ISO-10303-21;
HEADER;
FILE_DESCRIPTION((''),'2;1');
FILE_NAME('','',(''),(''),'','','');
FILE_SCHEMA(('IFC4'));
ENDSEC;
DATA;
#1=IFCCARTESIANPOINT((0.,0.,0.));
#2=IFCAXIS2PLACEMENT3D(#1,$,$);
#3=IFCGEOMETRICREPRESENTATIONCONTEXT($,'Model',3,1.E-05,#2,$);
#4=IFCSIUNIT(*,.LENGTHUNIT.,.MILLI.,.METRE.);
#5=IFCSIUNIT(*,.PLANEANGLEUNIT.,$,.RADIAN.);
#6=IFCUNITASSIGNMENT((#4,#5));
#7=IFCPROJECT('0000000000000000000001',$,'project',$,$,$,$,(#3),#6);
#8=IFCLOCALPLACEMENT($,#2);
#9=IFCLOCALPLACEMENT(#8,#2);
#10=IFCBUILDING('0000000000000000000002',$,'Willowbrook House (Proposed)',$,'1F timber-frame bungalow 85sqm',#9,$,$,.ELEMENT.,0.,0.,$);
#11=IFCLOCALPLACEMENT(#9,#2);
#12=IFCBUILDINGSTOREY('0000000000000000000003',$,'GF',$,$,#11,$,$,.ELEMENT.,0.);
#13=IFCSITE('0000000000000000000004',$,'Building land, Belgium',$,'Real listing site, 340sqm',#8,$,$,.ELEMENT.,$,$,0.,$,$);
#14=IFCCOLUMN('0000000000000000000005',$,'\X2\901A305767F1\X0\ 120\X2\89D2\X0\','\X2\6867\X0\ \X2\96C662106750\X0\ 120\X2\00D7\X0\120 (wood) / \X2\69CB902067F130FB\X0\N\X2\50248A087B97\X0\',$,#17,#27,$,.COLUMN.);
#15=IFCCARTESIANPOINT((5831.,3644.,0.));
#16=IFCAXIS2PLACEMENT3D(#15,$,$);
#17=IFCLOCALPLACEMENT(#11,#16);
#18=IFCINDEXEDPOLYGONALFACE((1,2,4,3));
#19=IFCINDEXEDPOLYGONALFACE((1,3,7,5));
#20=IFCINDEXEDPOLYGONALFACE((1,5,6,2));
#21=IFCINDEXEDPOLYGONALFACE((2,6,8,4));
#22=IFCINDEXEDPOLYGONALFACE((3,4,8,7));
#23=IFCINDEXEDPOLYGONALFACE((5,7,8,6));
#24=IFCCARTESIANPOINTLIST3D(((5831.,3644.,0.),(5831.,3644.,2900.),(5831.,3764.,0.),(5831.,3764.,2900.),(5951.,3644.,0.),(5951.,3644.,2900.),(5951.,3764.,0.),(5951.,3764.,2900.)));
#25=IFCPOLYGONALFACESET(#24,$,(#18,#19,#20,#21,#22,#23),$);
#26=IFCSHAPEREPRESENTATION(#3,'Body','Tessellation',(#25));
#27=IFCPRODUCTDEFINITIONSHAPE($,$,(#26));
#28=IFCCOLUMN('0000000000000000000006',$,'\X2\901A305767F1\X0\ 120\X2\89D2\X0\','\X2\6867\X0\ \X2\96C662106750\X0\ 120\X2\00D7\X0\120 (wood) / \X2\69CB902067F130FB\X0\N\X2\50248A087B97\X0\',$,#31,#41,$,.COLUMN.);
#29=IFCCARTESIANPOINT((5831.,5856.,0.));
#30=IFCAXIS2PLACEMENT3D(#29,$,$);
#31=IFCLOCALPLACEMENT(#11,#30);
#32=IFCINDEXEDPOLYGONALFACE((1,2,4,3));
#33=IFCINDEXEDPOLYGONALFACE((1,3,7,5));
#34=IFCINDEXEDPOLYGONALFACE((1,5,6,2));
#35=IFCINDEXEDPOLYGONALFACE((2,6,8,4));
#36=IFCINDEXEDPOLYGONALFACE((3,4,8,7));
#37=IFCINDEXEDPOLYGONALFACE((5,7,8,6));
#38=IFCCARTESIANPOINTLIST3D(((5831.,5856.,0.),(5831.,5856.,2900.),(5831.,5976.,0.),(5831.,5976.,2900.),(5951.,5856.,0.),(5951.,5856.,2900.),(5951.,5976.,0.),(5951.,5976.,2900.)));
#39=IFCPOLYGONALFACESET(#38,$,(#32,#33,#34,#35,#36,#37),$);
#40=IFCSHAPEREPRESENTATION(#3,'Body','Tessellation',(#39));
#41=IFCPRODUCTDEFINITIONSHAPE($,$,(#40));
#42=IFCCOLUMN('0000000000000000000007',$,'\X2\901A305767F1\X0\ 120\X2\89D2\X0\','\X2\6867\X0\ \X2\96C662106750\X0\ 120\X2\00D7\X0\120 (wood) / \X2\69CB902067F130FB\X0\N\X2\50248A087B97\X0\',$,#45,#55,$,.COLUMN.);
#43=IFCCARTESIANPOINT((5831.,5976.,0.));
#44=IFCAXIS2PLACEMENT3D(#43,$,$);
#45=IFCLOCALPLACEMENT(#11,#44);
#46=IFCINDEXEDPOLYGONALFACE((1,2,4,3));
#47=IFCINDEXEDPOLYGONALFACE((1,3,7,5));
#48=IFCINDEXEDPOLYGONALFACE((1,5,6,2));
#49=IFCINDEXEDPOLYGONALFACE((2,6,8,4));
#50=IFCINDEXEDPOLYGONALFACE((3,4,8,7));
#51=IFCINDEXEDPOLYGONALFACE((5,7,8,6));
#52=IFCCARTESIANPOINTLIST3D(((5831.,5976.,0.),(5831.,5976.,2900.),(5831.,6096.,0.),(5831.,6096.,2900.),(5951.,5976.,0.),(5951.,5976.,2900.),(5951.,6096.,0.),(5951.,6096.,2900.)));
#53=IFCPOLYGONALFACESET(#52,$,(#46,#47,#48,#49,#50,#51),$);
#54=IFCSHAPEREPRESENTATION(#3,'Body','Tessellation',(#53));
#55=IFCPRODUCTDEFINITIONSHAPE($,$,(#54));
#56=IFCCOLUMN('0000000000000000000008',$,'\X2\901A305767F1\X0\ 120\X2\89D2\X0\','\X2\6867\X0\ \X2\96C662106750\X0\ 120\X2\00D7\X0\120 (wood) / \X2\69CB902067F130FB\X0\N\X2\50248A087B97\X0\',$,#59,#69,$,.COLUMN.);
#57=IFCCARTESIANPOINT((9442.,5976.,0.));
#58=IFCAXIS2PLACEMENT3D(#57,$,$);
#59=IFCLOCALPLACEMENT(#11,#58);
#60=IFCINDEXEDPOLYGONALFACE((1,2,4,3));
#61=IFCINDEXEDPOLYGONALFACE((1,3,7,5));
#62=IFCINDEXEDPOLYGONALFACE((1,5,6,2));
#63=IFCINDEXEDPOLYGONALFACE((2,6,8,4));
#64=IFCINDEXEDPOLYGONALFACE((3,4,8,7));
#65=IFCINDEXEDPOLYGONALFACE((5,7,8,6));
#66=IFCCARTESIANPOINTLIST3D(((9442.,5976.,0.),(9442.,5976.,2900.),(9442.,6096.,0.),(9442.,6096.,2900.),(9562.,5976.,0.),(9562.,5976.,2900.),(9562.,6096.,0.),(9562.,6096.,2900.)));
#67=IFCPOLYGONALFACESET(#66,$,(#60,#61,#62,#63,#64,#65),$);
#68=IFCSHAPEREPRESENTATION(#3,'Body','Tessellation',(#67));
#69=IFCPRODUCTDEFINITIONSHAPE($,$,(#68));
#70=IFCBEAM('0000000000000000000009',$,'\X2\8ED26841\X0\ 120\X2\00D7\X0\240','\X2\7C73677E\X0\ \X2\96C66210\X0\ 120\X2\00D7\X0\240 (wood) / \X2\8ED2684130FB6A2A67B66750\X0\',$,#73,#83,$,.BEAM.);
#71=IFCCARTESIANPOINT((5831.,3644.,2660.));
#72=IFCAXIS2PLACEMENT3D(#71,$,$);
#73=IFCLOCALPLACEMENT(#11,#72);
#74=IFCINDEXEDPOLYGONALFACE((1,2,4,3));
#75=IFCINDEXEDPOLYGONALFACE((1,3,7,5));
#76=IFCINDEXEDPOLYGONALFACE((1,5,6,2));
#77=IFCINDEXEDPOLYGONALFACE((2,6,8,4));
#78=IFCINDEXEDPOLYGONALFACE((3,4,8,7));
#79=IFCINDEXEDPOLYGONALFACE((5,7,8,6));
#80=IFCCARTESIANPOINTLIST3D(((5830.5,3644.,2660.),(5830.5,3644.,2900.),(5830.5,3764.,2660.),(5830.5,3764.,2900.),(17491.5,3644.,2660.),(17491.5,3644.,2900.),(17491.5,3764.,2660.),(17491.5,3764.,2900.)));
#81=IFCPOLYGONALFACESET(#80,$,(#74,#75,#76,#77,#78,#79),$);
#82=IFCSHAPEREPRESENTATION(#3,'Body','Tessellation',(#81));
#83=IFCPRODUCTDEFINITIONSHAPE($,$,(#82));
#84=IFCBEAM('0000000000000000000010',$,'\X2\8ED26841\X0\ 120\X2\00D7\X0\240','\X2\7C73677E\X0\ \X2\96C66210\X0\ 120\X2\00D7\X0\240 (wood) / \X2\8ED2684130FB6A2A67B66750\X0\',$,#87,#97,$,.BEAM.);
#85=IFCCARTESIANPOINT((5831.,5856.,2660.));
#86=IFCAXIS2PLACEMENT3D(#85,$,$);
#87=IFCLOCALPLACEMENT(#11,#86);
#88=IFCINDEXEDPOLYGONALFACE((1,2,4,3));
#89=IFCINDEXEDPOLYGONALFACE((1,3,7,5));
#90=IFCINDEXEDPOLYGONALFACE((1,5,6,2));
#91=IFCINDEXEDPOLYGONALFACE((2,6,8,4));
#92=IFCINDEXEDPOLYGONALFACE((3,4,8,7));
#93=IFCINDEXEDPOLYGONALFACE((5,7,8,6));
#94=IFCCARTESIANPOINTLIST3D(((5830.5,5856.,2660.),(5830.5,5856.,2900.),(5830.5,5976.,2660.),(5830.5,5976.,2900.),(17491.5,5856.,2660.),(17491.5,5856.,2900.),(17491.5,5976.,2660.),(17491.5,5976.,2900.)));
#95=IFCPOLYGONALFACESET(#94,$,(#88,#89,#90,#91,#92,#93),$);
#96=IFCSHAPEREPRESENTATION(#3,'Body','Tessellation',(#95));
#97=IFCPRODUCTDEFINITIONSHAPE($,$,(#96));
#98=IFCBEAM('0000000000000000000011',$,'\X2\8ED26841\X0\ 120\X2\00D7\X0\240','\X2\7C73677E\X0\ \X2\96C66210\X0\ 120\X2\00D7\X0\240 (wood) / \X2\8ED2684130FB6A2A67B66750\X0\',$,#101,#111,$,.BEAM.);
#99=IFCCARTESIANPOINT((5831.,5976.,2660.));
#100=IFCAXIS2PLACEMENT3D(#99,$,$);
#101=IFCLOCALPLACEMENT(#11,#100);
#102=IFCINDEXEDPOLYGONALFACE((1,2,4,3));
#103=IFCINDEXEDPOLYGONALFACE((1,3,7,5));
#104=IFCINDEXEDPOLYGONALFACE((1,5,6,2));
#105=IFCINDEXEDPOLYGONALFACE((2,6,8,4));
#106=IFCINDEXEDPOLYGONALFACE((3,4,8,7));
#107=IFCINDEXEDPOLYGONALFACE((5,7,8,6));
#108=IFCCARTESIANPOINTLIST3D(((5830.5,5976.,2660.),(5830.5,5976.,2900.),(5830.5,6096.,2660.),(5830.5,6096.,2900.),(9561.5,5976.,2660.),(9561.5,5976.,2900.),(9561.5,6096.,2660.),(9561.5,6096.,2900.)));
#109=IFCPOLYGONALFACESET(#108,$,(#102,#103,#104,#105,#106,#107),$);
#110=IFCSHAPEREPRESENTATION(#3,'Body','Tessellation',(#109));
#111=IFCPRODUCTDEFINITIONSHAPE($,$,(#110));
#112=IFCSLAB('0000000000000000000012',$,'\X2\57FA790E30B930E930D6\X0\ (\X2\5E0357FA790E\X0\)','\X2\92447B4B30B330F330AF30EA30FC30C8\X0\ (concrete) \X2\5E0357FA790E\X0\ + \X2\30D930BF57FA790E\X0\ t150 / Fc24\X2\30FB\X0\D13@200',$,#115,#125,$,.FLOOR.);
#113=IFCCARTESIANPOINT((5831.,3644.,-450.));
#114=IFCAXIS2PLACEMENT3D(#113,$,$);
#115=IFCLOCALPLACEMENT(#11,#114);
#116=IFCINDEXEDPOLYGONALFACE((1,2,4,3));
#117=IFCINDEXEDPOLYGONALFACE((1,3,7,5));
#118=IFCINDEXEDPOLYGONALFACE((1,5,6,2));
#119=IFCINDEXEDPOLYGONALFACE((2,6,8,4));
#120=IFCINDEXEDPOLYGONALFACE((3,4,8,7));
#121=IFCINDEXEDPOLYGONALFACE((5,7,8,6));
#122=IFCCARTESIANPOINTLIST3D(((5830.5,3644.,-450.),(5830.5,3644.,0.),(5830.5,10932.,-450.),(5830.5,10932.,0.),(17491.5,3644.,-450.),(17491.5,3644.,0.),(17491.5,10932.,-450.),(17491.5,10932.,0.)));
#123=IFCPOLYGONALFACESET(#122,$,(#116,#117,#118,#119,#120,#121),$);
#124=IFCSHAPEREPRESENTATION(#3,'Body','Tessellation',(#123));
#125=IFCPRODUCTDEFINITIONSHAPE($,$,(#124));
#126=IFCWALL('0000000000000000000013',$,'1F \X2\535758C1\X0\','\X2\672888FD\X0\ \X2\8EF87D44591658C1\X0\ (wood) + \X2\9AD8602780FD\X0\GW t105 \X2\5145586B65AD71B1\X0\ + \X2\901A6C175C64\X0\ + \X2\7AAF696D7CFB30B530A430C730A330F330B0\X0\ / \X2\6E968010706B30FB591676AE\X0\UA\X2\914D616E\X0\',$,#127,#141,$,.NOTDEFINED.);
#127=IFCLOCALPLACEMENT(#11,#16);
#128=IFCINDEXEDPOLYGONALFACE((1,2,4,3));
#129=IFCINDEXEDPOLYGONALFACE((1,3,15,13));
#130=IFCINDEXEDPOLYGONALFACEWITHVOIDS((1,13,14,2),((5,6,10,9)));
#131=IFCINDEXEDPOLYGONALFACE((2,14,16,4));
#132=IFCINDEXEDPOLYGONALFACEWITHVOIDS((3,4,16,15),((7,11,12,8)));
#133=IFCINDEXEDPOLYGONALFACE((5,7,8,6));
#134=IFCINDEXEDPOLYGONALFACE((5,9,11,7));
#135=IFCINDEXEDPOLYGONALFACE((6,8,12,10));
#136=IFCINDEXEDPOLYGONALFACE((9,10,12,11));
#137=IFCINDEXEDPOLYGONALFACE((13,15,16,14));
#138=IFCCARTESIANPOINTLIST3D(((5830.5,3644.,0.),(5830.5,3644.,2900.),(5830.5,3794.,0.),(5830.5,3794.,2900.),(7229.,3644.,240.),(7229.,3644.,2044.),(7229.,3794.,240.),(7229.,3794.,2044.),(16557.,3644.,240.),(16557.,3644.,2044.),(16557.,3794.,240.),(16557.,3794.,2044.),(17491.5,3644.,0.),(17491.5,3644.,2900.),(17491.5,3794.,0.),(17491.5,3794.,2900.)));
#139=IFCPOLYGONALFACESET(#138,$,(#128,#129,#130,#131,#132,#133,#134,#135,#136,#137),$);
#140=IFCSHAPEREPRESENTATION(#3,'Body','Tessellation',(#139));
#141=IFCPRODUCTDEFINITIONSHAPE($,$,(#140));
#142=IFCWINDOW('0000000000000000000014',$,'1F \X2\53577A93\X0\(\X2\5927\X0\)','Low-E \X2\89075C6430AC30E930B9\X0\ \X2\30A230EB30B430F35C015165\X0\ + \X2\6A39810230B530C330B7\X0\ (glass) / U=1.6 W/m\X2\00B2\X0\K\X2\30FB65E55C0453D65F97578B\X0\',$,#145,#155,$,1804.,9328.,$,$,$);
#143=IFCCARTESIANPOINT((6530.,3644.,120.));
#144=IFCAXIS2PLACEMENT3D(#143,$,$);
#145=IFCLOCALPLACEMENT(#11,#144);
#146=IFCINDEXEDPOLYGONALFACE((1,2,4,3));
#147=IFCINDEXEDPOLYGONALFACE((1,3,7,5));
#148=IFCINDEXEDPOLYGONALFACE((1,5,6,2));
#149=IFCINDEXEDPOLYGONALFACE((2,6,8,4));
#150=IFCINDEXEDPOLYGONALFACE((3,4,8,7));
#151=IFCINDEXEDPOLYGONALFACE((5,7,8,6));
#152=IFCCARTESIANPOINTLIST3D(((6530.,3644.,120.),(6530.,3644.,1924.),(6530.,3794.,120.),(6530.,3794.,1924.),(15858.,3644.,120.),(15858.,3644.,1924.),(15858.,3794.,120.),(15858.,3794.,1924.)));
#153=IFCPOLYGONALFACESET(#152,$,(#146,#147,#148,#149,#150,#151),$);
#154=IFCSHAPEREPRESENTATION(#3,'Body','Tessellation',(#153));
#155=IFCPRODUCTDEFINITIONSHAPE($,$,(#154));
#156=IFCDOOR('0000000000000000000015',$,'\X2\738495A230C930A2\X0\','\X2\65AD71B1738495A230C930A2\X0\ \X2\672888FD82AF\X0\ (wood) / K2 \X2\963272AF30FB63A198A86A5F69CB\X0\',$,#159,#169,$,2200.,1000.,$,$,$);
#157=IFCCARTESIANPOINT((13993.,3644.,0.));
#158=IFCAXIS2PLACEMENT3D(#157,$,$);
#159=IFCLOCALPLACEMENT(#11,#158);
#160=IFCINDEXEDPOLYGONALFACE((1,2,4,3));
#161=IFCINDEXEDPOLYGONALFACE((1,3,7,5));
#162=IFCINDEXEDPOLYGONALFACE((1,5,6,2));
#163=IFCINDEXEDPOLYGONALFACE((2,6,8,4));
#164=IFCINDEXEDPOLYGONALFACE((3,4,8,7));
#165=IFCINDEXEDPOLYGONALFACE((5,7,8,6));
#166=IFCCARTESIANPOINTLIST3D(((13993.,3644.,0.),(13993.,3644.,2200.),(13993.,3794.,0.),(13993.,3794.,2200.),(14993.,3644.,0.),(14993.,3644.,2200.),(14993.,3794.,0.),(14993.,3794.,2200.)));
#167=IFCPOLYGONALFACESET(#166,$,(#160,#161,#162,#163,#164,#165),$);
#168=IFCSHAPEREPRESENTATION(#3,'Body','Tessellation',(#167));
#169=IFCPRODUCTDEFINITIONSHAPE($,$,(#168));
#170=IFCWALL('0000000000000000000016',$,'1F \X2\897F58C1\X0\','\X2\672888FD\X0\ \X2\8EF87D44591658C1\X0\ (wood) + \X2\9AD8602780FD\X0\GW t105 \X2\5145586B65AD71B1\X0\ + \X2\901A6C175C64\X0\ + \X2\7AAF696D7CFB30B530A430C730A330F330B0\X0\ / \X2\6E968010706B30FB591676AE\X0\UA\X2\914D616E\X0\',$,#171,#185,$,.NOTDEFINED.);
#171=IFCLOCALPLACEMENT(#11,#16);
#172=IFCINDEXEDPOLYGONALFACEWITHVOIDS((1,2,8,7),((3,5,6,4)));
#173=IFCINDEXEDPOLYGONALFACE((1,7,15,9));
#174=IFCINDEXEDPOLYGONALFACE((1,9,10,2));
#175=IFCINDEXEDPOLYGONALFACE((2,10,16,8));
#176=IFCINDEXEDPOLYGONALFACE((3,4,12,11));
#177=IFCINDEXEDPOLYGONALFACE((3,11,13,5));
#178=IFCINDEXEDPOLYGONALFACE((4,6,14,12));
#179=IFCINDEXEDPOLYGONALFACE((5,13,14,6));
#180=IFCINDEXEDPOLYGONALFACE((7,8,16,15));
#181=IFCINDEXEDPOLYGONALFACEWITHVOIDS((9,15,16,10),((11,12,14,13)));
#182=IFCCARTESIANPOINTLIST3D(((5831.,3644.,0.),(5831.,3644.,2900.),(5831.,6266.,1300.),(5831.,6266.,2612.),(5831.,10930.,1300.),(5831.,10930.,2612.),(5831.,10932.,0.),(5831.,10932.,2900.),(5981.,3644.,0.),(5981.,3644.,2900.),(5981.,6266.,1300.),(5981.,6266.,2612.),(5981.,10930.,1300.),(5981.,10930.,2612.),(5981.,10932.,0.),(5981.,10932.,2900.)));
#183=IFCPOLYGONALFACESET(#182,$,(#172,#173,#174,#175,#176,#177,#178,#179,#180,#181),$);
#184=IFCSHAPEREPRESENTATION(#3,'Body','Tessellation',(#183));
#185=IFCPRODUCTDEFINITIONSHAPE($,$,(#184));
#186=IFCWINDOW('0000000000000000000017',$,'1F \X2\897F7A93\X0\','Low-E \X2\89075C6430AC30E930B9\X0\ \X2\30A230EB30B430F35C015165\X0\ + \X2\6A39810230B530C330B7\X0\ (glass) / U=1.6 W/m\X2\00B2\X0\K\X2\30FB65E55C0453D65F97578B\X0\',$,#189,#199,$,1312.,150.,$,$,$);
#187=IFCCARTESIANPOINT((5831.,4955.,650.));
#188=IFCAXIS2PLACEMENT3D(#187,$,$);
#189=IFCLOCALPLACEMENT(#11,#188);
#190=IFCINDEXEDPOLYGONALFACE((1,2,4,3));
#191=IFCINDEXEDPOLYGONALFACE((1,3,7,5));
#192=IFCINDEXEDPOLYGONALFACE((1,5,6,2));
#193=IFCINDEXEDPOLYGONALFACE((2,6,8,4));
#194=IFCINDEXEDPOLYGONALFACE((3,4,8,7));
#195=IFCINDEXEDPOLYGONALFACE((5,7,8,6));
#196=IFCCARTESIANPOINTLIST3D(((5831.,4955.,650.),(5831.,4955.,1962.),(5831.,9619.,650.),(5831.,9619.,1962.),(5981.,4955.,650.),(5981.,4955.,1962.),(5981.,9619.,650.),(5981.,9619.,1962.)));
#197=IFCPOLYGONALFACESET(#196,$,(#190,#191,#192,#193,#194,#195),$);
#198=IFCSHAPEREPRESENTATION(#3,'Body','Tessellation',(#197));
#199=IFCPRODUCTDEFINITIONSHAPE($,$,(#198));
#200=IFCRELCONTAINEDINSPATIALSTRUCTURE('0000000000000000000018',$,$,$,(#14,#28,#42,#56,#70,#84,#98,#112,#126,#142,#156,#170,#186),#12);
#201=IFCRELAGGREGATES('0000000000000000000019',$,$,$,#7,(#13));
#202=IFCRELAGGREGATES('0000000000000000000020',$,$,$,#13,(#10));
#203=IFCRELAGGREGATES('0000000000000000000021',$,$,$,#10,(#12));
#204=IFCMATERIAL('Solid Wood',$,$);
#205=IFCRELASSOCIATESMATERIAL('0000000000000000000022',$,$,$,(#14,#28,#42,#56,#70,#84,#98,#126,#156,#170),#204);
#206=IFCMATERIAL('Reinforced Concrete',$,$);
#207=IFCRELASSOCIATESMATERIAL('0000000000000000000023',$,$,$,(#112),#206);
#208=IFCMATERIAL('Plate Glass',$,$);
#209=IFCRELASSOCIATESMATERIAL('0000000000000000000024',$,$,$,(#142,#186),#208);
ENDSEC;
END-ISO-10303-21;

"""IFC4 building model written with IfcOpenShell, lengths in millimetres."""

from ifc_helpers import new_model, si_unit, frame, frame_2d, origin, place, context, project, spatial, rectangle, extrude, material, element, fill, save


model = new_model("IFC4")

# Units and contexts
model_context = context("Model", 3, precision=1e-05, world=origin())
ifc_project = project(units=[si_unit("LENGTHUNIT", "METRE", prefix="MILLI"), si_unit("PLANEANGLEUNIT", "RADIAN")], contexts=[model_context])

# Site, building, storey
site_placement = place(None, origin())
site = spatial("IfcSite", under=ifc_project, at=site_placement, Name="Building land, Belgium", ObjectType="Real listing site, 340sqm", CompositionType="ELEMENT", RefElevation=0.0)
building_placement = place(site_placement, origin())
building = spatial("IfcBuilding", under=site, at=building_placement, Name="Willowbrook House (Proposed)", ObjectType="1F timber-frame bungalow 85sqm", CompositionType="ELEMENT", ElevationOfRefHeight=0.0, ElevationOfTerrain=0.0)
storey_placement = place(building_placement, origin())
storey = spatial("IfcBuildingStorey", under=building, at=storey_placement, Name="GF", CompositionType="ELEMENT", Elevation=0.0)

# Columns
ifc_material_1 = material(Name="Solid Wood")
column_1_placement = place(storey_placement, frame((5831.0, 3644.0, 0.0)))
element("IfcColumn", 1, at=column_1_placement, inside=storey, material=ifc_material_1, Name="通し柱 120角", Description="桧 集成材 120×120 (wood) / 構造柱・N値計算", PredefinedType="COLUMN", context=model_context, shape_type="SweptSolid", body=[
    extrude(rectangle(XDim=120.0, YDim=120.0, at=frame_2d((60.0, 60.0))), frame((5831.0, 3644.0, 0.0)), (0.0, 0.0, 1.0), 2900.0),
])
column_2_placement = place(storey_placement, frame((5831.0, 5856.0, 0.0)))
element("IfcColumn", 2, at=column_2_placement, inside=storey, material=ifc_material_1, Name="通し柱 120角", Description="桧 集成材 120×120 (wood) / 構造柱・N値計算", PredefinedType="COLUMN", context=model_context, shape_type="SweptSolid", body=[
    extrude(rectangle(XDim=120.0, YDim=120.0, at=frame_2d((60.0, 60.0))), frame((5831.0, 5856.0, 0.0)), (0.0, 0.0, 1.0), 2900.0),
])
column_3_placement = place(storey_placement, frame((5831.0, 5976.0, 0.0)))
element("IfcColumn", 3, at=column_3_placement, inside=storey, material=ifc_material_1, Name="通し柱 120角", Description="桧 集成材 120×120 (wood) / 構造柱・N値計算", PredefinedType="COLUMN", context=model_context, shape_type="SweptSolid", body=[
    extrude(rectangle(XDim=120.0, YDim=120.0, at=frame_2d((60.0, 60.0))), frame((5831.0, 5976.0, 0.0)), (0.0, 0.0, 1.0), 2900.0),
])
column_4_placement = place(storey_placement, frame((9442.0, 5976.0, 0.0)))
element("IfcColumn", 4, at=column_4_placement, inside=storey, material=ifc_material_1, Name="通し柱 120角", Description="桧 集成材 120×120 (wood) / 構造柱・N値計算", PredefinedType="COLUMN", context=model_context, shape_type="SweptSolid", body=[
    extrude(rectangle(XDim=120.0, YDim=120.0, at=frame_2d((60.0, 60.0))), frame((9442.0, 5976.0, 0.0)), (0.0, 0.0, 1.0), 2900.0),
])

# Beams
beam_1_placement = place(storey_placement, frame((5831.0, 3644.0, 2660.0)))
element("IfcBeam", 5, at=beam_1_placement, inside=storey, material=ifc_material_1, Name="軒桁 120×240", Description="米松 集成 120×240 (wood) / 軒桁・横架材", PredefinedType="BEAM", context=model_context, shape_type="SweptSolid", body=[
    extrude(rectangle(XDim=11661.0, YDim=120.0, at=frame_2d((5830.0, 60.0))), frame((5831.0, 3644.0, 2660.0)), (0.0, 0.0, 1.0), 240.0),
])
beam_2_placement = place(storey_placement, frame((5831.0, 5856.0, 2660.0)))
element("IfcBeam", 6, at=beam_2_placement, inside=storey, material=ifc_material_1, Name="軒桁 120×240", Description="米松 集成 120×240 (wood) / 軒桁・横架材", PredefinedType="BEAM", context=model_context, shape_type="SweptSolid", body=[
    extrude(rectangle(XDim=11661.0, YDim=120.0, at=frame_2d((5830.0, 60.0))), frame((5831.0, 5856.0, 2660.0)), (0.0, 0.0, 1.0), 240.0),
])
beam_3_placement = place(storey_placement, frame((5831.0, 5976.0, 2660.0)))
element("IfcBeam", 7, at=beam_3_placement, inside=storey, material=ifc_material_1, Name="軒桁 120×240", Description="米松 集成 120×240 (wood) / 軒桁・横架材", PredefinedType="BEAM", context=model_context, shape_type="SweptSolid", body=[
    extrude(rectangle(XDim=3731.0, YDim=120.0, at=frame_2d((1865.0, 60.0))), frame((5831.0, 5976.0, 2660.0)), (0.0, 0.0, 1.0), 240.0),
])

# Slab
ifc_material_2 = material(Name="Reinforced Concrete")
slab_1_placement = place(storey_placement, frame((5831.0, 3644.0, -450.0)))
element("IfcSlab", 8, at=slab_1_placement, inside=storey, material=ifc_material_2, Name="基礎スラブ (布基礎)", Description="鉄筋コンクリート (concrete) 布基礎 + ベタ基礎 t150 / Fc24・D13@200", PredefinedType="FLOOR", context=model_context, shape_type="SweptSolid", body=[
    extrude(rectangle(XDim=11661.0, YDim=7288.0, at=frame_2d((5830.0, 3644.0))), frame((5831.0, 3644.0, -450.0)), (0.0, 0.0, 1.0), 450.0),
])

# Wall, openings, window, door
wall_1_placement = place(storey_placement, frame((5831.0, 3644.0, 0.0)))
wall_1 = element("IfcWall", 9, at=wall_1_placement, inside=storey, material=ifc_material_1, Name="1F 南壁", Description="木製 軸組外壁 (wood) + 高性能GW t105 充填断熱 + 通気層 + 窯業系サイディング / 準耐火・外皮UA配慮", PredefinedType="NOTDEFINED", context=model_context, shape_type="SweptSolid", body=[
    extrude(rectangle(XDim=11661.0, YDim=150.0, at=frame_2d((5830.0, 75.0))), frame((5831.0, 3644.0, 0.0)), (0.0, 0.0, 1.0), 2900.0),
])
opening_1_placement = place(storey_placement, frame((6530.0, 3644.0, 120.0)))
opening_1 = element("IfcOpeningElement", 10, at=opening_1_placement, cuts=wall_1, PredefinedType="NOTDEFINED", context=model_context, shape_type="SweptSolid", body=[
    extrude(rectangle(XDim=9328.0, YDim=150.0, at=frame_2d((4664.0, 75.0))), frame((6530.0, 3644.0, 120.0)), (0.0, 0.0, 1.0), 1804.0),
])
opening_2_placement = place(storey_placement, frame((13993.0, 3644.0, 0.0)))
opening_2 = element("IfcOpeningElement", 11, at=opening_2_placement, cuts=wall_1, PredefinedType="NOTDEFINED", context=model_context, shape_type="SweptSolid", body=[
    extrude(rectangle(XDim=1000.0, YDim=150.0, at=frame_2d((500.0, 75.0))), frame((13993.0, 3644.0, 0.0)), (0.0, 0.0, 1.0), 2200.0),
])
ifc_material_3 = material(Name="Plate Glass")
window_1_placement = place(storey_placement, frame((6530.0, 3644.0, 120.0)))
window_1 = element("IfcWindow", 12, at=window_1_placement, inside=storey, material=ifc_material_3, Name="1F 南窓(大)", Description="Low-E 複層ガラス アルゴン封入 + 樹脂サッシ (glass) / U=1.6 W/m²K・日射取得型", OverallHeight=1804.0, OverallWidth=9328.0, context=model_context, shape_type="SweptSolid", body=[
    extrude(rectangle(XDim=9328.0, YDim=150.0, at=frame_2d((4664.0, 75.0))), frame((6530.0, 3644.0, 120.0)), (0.0, 0.0, 1.0), 1804.0),
])
fill(opening_1, window_1)
door_placement = place(storey_placement, frame((13993.0, 3644.0, 0.0)))
door = element("IfcDoor", 13, at=door_placement, inside=storey, material=ifc_material_1, Name="玄関ドア", Description="断熱玄関ドア 木製芯 (wood) / K2 防犯・採風機構", OverallHeight=2200.0, OverallWidth=1000.0, context=model_context, shape_type="SweptSolid", body=[
    extrude(rectangle(XDim=1000.0, YDim=150.0, at=frame_2d((500.0, 75.0))), frame((13993.0, 3644.0, 0.0)), (0.0, 0.0, 1.0), 2200.0),
])
fill(opening_2, door)

# Wall, opening, window
wall_2_placement = place(storey_placement, frame((5831.0, 3644.0, 0.0)))
wall_2 = element("IfcWall", 14, at=wall_2_placement, inside=storey, material=ifc_material_1, Name="1F 西壁", Description="木製 軸組外壁 (wood) + 高性能GW t105 充填断熱 + 通気層 + 窯業系サイディング / 準耐火・外皮UA配慮", PredefinedType="NOTDEFINED", context=model_context, shape_type="SweptSolid", body=[
    extrude(rectangle(XDim=150.0, YDim=7288.0, at=frame_2d((75.0, 3644.0))), frame((5831.0, 3644.0, 0.0)), (0.0, 0.0, 1.0), 2900.0),
])
opening_3_placement = place(storey_placement, frame((5831.0, 4955.0, 650.0)))
opening_3 = element("IfcOpeningElement", 15, at=opening_3_placement, cuts=wall_2, PredefinedType="NOTDEFINED", context=model_context, shape_type="SweptSolid", body=[
    extrude(rectangle(XDim=150.0, YDim=4664.0, at=frame_2d((75.0, 2332.0))), frame((5831.0, 4955.0, 650.0)), (0.0, 0.0, 1.0), 1312.0),
])
window_2_placement = place(storey_placement, frame((5831.0, 4955.0, 650.0)))
window_2 = element("IfcWindow", 16, at=window_2_placement, inside=storey, material=ifc_material_3, Name="1F 西窓", Description="Low-E 複層ガラス アルゴン封入 + 樹脂サッシ (glass) / U=1.6 W/m²K・日射取得型", OverallHeight=1312.0, OverallWidth=150.0, context=model_context, shape_type="SweptSolid", body=[
    extrude(rectangle(XDim=150.0, YDim=4664.0, at=frame_2d((75.0, 2332.0))), frame((5831.0, 4955.0, 650.0)), (0.0, 0.0, 1.0), 1312.0),
])
fill(opening_3, window_2)

save(model, "model.ifc")
